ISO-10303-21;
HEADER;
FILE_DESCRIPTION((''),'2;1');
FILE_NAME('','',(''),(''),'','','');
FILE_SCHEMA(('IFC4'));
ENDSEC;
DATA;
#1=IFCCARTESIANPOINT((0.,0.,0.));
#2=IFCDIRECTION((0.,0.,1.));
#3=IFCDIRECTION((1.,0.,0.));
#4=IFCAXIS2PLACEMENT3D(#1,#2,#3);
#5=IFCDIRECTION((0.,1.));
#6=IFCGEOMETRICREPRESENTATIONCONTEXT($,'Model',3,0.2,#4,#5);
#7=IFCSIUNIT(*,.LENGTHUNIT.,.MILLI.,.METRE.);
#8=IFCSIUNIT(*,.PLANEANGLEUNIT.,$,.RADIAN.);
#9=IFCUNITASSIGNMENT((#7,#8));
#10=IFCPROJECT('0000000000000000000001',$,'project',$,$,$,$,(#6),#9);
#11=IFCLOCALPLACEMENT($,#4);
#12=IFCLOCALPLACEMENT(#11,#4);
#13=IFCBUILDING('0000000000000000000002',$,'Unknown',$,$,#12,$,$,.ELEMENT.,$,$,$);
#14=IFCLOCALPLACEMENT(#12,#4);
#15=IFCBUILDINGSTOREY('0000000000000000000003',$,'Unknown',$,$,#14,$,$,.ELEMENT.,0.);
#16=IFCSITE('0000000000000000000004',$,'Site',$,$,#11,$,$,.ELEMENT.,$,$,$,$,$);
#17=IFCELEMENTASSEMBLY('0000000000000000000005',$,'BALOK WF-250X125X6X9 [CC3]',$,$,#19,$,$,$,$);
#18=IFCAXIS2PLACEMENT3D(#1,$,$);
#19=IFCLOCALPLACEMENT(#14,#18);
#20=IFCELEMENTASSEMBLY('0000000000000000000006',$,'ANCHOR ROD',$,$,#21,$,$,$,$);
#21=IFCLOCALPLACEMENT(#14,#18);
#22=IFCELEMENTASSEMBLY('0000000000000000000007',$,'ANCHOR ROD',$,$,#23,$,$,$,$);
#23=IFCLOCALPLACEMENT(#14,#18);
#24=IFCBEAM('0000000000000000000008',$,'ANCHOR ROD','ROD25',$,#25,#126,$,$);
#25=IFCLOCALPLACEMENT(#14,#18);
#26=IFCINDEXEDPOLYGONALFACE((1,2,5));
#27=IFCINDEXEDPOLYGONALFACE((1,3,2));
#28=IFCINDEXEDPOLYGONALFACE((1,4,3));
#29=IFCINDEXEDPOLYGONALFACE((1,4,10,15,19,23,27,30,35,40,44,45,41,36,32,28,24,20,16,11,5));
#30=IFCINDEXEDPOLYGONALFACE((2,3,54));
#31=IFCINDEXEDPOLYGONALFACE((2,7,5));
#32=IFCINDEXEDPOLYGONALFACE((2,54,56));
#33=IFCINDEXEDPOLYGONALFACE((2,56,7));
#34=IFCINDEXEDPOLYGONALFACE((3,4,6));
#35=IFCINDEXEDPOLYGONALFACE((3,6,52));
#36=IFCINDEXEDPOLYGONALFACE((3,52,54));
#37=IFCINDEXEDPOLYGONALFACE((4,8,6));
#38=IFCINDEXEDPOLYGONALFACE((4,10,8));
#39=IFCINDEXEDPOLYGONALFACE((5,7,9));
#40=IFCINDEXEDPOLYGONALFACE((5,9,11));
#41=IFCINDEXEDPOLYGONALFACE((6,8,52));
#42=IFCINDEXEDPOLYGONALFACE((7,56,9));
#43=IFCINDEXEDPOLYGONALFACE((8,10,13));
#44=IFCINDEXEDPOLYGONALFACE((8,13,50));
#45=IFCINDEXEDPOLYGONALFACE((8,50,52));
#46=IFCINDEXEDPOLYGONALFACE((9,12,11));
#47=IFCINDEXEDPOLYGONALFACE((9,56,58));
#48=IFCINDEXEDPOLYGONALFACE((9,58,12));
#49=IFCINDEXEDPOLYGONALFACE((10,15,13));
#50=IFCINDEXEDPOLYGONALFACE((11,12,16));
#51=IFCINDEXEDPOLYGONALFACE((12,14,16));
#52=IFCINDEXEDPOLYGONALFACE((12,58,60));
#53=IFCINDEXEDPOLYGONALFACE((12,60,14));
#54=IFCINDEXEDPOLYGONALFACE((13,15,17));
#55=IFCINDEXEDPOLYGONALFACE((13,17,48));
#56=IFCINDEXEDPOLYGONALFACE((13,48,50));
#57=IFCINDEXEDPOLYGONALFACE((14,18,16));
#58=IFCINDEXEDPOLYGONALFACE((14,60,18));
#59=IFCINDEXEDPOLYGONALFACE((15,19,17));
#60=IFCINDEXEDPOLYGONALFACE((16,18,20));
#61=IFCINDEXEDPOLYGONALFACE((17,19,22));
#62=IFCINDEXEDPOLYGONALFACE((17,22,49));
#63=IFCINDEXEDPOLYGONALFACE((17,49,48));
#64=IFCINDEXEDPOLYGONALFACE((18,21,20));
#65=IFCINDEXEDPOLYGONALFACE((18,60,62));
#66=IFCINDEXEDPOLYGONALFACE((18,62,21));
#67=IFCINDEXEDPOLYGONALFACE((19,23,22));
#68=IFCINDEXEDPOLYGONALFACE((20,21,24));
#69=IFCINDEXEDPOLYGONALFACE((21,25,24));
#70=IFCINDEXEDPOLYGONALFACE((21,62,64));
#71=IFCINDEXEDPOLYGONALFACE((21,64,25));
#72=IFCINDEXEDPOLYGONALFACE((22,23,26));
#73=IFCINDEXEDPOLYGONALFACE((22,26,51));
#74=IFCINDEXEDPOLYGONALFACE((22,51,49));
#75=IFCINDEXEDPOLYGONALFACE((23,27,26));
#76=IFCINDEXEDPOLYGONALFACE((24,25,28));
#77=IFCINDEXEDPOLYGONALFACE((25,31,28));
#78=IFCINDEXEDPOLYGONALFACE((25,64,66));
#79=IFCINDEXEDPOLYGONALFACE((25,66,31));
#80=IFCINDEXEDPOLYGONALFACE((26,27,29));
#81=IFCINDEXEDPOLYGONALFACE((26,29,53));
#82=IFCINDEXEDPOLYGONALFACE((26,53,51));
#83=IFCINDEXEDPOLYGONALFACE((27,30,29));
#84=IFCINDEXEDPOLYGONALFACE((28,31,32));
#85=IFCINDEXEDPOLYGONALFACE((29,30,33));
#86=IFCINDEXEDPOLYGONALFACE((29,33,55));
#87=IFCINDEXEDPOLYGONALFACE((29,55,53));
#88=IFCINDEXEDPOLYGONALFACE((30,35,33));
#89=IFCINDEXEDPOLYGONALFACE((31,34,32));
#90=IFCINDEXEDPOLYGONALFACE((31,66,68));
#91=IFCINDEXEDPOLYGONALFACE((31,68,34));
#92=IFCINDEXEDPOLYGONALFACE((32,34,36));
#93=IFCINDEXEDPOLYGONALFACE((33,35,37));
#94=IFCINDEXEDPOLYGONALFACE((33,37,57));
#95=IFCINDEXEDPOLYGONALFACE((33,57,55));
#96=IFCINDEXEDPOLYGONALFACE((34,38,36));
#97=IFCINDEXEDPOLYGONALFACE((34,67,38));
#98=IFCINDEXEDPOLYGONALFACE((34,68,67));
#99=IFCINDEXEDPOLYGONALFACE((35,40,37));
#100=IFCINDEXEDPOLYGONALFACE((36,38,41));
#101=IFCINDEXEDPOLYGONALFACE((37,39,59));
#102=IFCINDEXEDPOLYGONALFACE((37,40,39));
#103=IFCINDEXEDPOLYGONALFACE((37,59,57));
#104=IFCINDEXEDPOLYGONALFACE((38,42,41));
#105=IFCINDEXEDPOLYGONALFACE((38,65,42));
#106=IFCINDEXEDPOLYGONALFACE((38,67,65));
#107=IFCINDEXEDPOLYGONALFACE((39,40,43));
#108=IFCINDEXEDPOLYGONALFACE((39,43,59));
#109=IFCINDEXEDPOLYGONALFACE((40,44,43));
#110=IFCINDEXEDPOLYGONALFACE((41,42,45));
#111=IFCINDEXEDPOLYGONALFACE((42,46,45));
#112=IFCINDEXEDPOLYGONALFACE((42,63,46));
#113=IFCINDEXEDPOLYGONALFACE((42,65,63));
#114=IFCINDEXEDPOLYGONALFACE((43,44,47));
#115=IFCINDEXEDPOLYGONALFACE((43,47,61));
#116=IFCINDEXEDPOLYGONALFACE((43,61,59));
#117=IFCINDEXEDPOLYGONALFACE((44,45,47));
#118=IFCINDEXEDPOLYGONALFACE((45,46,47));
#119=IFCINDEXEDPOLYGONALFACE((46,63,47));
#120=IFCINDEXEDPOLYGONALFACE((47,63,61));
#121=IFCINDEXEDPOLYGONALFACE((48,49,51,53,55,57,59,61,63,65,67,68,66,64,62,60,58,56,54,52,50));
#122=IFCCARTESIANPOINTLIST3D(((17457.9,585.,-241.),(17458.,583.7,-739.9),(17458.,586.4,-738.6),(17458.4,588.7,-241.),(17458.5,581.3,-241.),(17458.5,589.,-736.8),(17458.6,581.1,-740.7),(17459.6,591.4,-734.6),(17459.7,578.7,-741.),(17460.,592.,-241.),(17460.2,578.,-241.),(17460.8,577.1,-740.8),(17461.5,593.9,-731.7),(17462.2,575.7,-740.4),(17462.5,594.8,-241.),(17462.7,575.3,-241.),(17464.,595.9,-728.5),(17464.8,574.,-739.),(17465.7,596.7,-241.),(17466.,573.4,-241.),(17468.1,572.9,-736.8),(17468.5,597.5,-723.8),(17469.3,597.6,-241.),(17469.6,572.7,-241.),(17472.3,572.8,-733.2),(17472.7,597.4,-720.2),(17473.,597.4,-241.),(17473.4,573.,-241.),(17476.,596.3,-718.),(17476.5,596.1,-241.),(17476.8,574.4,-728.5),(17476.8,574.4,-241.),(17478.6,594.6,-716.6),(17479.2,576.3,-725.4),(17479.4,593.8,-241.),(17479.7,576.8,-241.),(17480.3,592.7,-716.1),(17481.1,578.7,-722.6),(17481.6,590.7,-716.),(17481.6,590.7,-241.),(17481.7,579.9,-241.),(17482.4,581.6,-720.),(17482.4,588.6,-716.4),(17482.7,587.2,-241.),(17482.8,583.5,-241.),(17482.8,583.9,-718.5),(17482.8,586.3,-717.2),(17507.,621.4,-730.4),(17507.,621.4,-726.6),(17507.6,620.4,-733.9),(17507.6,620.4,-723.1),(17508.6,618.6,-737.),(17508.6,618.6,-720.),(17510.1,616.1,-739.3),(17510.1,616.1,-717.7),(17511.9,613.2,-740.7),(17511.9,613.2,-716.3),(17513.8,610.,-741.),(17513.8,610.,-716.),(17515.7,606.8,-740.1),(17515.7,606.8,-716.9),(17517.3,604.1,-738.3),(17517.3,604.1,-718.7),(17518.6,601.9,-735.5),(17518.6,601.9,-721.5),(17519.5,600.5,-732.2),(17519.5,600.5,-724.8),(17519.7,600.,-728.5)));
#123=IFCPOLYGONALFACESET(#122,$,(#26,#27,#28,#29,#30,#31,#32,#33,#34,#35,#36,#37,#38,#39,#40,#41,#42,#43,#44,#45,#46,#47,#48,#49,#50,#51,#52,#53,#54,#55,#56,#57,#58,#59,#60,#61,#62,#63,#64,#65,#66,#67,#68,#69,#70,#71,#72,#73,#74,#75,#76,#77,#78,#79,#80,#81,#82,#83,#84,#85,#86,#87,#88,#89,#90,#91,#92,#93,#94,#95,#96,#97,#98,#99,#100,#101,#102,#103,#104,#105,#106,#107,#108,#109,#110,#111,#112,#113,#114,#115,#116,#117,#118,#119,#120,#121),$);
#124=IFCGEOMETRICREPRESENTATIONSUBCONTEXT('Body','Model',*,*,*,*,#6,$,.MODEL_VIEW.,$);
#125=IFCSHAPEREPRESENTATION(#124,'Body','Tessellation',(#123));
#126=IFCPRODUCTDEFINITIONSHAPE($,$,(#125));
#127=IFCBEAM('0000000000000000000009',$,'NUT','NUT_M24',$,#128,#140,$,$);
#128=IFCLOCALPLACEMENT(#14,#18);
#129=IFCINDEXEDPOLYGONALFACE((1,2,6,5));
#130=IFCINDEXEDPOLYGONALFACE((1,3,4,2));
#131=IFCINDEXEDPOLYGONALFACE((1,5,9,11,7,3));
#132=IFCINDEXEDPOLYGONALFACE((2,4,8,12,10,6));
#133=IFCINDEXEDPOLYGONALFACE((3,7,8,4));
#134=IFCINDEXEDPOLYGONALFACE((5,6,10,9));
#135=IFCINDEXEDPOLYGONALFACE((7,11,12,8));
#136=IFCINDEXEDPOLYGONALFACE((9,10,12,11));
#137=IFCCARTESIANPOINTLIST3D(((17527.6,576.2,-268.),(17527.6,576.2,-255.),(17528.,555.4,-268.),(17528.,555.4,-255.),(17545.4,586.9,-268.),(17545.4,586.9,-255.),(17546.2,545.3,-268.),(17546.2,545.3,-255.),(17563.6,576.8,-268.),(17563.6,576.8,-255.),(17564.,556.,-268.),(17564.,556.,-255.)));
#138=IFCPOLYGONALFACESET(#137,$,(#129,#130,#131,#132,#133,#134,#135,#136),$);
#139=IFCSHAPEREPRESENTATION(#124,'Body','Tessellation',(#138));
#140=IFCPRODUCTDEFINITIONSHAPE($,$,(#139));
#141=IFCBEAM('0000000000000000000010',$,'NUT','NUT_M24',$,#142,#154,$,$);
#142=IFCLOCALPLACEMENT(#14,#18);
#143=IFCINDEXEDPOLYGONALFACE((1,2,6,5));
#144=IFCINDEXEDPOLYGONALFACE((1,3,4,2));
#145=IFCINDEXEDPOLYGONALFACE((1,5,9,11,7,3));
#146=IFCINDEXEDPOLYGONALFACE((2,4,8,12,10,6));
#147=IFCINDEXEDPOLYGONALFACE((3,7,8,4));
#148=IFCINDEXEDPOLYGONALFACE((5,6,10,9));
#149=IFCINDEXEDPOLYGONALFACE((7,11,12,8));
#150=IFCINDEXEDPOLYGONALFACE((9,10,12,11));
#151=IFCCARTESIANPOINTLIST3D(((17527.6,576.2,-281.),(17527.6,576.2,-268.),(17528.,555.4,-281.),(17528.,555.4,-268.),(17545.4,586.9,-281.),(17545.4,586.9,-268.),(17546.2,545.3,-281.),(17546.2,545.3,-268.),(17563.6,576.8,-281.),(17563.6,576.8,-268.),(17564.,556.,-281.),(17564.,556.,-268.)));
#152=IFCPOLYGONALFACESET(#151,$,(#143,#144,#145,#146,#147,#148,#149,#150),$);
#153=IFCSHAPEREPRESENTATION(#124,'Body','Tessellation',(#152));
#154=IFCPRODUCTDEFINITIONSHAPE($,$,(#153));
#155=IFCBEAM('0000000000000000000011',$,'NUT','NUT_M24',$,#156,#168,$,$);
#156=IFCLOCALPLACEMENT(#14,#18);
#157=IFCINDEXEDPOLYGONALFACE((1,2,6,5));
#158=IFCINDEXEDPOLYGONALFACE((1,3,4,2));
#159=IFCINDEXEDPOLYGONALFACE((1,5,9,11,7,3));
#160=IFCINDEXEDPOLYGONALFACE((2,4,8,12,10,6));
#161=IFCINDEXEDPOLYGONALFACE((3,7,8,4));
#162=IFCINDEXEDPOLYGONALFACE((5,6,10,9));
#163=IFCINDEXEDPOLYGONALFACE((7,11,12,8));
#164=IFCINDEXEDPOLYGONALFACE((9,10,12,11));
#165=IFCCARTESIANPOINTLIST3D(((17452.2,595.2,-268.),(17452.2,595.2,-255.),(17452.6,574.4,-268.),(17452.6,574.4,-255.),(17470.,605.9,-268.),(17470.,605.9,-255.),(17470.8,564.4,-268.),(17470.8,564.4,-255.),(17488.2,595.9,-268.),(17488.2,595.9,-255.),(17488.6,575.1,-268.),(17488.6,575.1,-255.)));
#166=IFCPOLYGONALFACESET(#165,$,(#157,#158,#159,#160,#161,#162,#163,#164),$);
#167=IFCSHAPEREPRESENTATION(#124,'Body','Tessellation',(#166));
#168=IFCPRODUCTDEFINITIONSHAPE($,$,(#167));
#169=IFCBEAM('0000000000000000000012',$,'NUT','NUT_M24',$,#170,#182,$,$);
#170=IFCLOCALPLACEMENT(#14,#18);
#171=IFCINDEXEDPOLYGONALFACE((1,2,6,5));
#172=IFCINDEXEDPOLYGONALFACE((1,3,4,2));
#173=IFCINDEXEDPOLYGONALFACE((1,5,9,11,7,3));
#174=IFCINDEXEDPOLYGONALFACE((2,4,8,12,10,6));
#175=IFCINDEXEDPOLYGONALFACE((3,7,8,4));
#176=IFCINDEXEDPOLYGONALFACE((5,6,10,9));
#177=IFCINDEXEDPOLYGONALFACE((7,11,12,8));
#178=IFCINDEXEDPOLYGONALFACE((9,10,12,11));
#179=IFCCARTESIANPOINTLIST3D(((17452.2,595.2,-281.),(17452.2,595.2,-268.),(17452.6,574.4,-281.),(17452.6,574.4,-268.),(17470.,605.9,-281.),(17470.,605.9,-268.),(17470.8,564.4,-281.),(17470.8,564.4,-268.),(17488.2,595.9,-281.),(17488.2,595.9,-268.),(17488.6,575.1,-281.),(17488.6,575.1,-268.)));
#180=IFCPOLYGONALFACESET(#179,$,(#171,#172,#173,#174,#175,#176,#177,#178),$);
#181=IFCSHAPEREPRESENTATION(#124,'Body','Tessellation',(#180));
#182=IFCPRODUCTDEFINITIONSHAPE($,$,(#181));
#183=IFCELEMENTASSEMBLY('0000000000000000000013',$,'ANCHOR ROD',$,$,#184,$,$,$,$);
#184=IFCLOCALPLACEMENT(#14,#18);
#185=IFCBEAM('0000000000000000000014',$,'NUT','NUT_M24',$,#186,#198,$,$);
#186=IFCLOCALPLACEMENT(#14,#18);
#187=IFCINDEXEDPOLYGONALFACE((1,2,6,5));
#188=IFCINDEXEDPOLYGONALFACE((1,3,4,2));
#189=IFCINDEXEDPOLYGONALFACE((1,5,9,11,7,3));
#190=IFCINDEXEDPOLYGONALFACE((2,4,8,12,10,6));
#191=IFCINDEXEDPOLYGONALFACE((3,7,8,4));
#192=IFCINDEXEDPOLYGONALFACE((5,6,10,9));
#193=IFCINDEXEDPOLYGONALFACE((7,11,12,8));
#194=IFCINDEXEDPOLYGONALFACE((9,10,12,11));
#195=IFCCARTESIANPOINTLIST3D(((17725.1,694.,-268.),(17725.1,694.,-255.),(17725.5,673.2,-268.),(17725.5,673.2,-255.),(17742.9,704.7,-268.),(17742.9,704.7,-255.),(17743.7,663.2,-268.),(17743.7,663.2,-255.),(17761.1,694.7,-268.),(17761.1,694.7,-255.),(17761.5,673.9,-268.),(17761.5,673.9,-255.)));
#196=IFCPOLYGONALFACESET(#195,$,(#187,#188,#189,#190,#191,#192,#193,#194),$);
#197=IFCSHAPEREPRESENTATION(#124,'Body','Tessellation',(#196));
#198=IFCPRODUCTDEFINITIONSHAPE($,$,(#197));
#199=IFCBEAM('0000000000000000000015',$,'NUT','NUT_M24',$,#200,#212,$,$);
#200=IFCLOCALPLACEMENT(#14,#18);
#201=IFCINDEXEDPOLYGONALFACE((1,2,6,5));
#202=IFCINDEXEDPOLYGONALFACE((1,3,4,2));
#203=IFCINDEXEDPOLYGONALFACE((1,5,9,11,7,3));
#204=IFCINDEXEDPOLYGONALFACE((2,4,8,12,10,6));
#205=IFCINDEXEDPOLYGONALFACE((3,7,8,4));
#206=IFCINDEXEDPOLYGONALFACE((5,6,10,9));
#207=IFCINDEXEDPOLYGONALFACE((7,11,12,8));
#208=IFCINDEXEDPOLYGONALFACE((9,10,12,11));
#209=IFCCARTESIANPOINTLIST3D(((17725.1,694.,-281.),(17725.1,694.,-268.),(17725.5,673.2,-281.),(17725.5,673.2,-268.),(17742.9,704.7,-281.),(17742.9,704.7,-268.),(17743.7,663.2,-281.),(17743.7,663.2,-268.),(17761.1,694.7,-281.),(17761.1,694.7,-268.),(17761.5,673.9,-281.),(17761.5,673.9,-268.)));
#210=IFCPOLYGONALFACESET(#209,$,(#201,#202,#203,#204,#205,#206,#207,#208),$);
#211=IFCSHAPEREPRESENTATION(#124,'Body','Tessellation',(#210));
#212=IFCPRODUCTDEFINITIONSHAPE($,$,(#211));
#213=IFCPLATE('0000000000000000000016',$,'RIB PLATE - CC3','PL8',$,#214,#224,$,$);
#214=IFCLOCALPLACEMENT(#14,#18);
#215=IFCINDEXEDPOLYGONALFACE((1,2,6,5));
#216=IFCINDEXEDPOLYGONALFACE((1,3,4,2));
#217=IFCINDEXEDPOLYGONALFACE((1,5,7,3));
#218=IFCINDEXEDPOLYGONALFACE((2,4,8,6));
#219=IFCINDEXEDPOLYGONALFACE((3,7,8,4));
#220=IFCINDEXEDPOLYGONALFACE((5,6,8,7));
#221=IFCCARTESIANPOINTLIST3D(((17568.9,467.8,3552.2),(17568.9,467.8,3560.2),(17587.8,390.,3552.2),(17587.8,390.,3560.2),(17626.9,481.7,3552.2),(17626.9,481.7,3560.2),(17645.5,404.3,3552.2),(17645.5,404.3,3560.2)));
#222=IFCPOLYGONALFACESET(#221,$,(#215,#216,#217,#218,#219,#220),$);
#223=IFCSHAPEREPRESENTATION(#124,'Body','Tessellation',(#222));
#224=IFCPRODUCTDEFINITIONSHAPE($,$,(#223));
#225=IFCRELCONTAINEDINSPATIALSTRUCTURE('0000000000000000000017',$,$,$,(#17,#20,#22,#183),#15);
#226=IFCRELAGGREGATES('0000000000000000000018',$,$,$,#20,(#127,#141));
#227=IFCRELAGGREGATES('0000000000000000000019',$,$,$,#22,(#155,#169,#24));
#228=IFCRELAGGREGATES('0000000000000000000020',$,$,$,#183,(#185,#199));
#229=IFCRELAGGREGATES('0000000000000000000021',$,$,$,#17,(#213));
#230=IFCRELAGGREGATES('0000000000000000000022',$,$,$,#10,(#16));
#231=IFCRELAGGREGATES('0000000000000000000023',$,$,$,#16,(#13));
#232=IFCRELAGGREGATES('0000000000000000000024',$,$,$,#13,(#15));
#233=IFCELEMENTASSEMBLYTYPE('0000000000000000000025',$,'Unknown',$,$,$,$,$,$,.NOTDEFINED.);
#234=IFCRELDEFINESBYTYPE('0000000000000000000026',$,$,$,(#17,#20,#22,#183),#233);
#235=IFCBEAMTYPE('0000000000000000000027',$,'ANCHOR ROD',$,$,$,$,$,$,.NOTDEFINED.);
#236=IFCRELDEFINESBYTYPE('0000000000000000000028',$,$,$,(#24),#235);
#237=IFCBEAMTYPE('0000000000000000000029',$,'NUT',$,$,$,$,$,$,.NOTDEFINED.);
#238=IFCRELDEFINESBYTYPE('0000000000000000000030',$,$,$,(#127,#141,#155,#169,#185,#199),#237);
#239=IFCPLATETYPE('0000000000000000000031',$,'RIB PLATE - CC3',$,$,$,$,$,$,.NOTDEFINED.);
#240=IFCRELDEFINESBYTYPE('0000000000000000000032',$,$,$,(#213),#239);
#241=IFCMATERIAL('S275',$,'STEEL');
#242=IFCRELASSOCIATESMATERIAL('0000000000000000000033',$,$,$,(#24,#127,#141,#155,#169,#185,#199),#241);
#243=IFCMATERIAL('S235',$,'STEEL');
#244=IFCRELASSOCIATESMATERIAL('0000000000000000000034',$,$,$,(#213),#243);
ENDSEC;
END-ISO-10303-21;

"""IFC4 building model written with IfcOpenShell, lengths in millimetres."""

from ifc_helpers import new_model, entity, si_unit, direction, frame, origin_with_axes, place, context, subcontext, project, spatial, polyline, line, indexed_curve, outline, extrude, material, material_profile, profile_set, profile_usage, type_object, element, aggregate, save


model = new_model("IFC4")

# Units and contexts
model_context = context("Model", 3, precision=0.2, world=origin_with_axes(), true_north=direction((0.0, 1.0)))
body_context = subcontext(model_context, "Body", "Model", "MODEL_VIEW")
ifc_project = project(units=[si_unit("LENGTHUNIT", "METRE", prefix="MILLI"), si_unit("PLANEANGLEUNIT", "RADIAN")], contexts=[model_context])

# Site, building, storey
site_placement = place(None, origin_with_axes())
site = spatial("IfcSite", under=ifc_project, at=site_placement, Name="Site", CompositionType="ELEMENT")
building_placement = place(site_placement, origin_with_axes())
building = spatial("IfcBuilding", under=site, at=building_placement, Name="Unknown", CompositionType="ELEMENT")
storey_placement = place(building_placement, origin_with_axes())
storey = spatial("IfcBuildingStorey", under=building, at=storey_placement, Name="Unknown", CompositionType="ELEMENT", Elevation=0.0)

# Element assemblies
element_assembly_type = type_object("IfcElementAssemblyType", Name="Unknown", PredefinedType="NOTDEFINED")
assembly_1_placement = place(storey_placement, frame((17628.6, 487.2, 3619.2), z_axis=(-0.972076, -0.234666, 0.0), x_axis=(0.234666, -0.972076, 0.0)))
assembly_1 = element("IfcElementAssembly", 1, at=assembly_1_placement, inside=storey, type_object=element_assembly_type, Name="BALOK WF-250X125X6X9 [CC3]")
assembly_2_placement = place(storey_placement, frame((17545.8, 566.1, -241.0), z_axis=(0.512428, -0.85873, 0.0), x_axis=(0.0, 0.0, -1.0)))
assembly_2 = element("IfcElementAssembly", 2, at=assembly_2_placement, inside=storey, type_object=element_assembly_type, Name="ANCHOR ROD")
ifc_material_1 = material(Name="S275", Category="STEEL")
assembly_3_placement = place(storey_placement, frame((17470.4, 585.1, -241.0), z_axis=(0.512428, -0.85873, 0.0), x_axis=(0.0, 0.0, -1.0)))
assembly_3 = element("IfcElementAssembly", 3, at=assembly_3_placement, inside=storey, type_object=element_assembly_type, Name="ANCHOR ROD")

# Beams
beam_type_1 = type_object("IfcBeamType", Name="ANCHOR ROD", PredefinedType="NOTDEFINED")
beam_1_placement = place(assembly_3_placement, origin_with_axes())
beam_1 = element("IfcBeam", 4, at=beam_1_placement, type_object=beam_type_1, material=ifc_material_1, Name="ANCHOR ROD", Description="ROD25", context=body_context, shape_type="SolidModel", body=[
    entity("IfcSweptDiskSolid", entity("IfcIndexedPolyCurve", entity("IfcCartesianPointList3D", [[0.0, 0.0, 0.0], [487.5, 0.0, 0.0], [487.5, 50.0, 0.0]]), [entity("IfcLineIndex", [1, 2, 3])]), 12.5),
])
ifc_material_profile_1 = material_profile(ifc_material_1, outline(polyline([(18.0, 10.4), (0.0, 20.8), (-18.0, 10.4), (-18.0, -10.4), (0.0, -20.8), (18.0, -10.4), (18.0, 10.4)])), Name="NUT_M24")
ifc_profile_set_1 = profile_set([ifc_material_profile_1])
ifc_profile_usage_1 = profile_usage(ifc_profile_set_1, cardinal=5)
beam_type_2 = type_object("IfcBeamType", Name="NUT", PredefinedType="NOTDEFINED")
beam_2_placement = place(assembly_2_placement, frame((14.0, 0.0, 0.0), z_axis=(0.0, -0.003454, -0.999994), x_axis=(1.0, 0.0, 0.0)))
beam_2 = element("IfcBeam", 5, at=beam_2_placement, type_object=beam_type_2, material=ifc_profile_usage_1, Name="NUT", Description="NUT_M24", context=body_context, shape_type="SolidModel", body=[
    extrude(outline(polyline([(18.0, 10.4), (0.0, 20.8), (-18.0, 10.4), (-18.0, -10.4), (0.0, -20.8), (18.0, -10.4), (18.0, 10.4)])), frame((0.0, 0.0, 0.0), z_axis=(-1.0, 0.0, 0.0), x_axis=(0.0, 0.0, 1.0)), (0.0, 0.0, -1.0), 13.0),
])
beam_3_placement = place(assembly_2_placement, frame((27.0, 0.0, 0.0), z_axis=(0.0, -0.003454, -0.999994), x_axis=(1.0, 0.0, 0.0)))
beam_3 = element("IfcBeam", 6, at=beam_3_placement, type_object=beam_type_2, material=ifc_profile_usage_1, Name="NUT", Description="NUT_M24", context=body_context, shape_type="SolidModel", body=[
    extrude(outline(polyline([(18.0, 10.4), (0.0, 20.8), (-18.0, 10.4), (-18.0, -10.4), (0.0, -20.8), (18.0, -10.4), (18.0, 10.4)])), frame((0.0, 0.0, 0.0), z_axis=(-1.0, 0.0, 0.0), x_axis=(0.0, 0.0, 1.0)), (0.0, 0.0, -1.0), 13.0),
])
aggregate(assembly_2, [beam_2, beam_3])
beam_4_placement = place(assembly_3_placement, frame((14.0, 0.0, 0.0), z_axis=(0.0, -0.003454, -0.999994), x_axis=(1.0, 0.0, 0.0)))
beam_4 = element("IfcBeam", 7, at=beam_4_placement, type_object=beam_type_2, material=ifc_profile_usage_1, Name="NUT", Description="NUT_M24", context=body_context, shape_type="SolidModel", body=[
    extrude(outline(polyline([(18.0, 10.4), (0.0, 20.8), (-18.0, 10.4), (-18.0, -10.4), (0.0, -20.8), (18.0, -10.4), (18.0, 10.4)])), frame((0.0, 0.0, 0.0), z_axis=(-1.0, 0.0, 0.0), x_axis=(0.0, 0.0, 1.0)), (0.0, 0.0, -1.0), 13.0),
])
beam_5_placement = place(assembly_3_placement, frame((27.0, 0.0, 0.0), z_axis=(0.0, -0.003454, -0.999994), x_axis=(1.0, 0.0, 0.0)))
beam_5 = element("IfcBeam", 8, at=beam_5_placement, type_object=beam_type_2, material=ifc_profile_usage_1, Name="NUT", Description="NUT_M24", context=body_context, shape_type="SolidModel", body=[
    extrude(outline(polyline([(18.0, 10.4), (0.0, 20.8), (-18.0, 10.4), (-18.0, -10.4), (0.0, -20.8), (18.0, -10.4), (18.0, 10.4)])), frame((0.0, 0.0, 0.0), z_axis=(-1.0, 0.0, 0.0), x_axis=(0.0, 0.0, 1.0)), (0.0, 0.0, -1.0), 13.0),
])
aggregate(assembly_3, [beam_4, beam_5, beam_1])

# Element assembly, beams
assembly_4_placement = place(storey_placement, frame((17743.3, 684.0, -241.0), z_axis=(-0.512426, 0.858731, 0.0), x_axis=(0.0, 0.0, -1.0)))
assembly_4 = element("IfcElementAssembly", 9, at=assembly_4_placement, inside=storey, type_object=element_assembly_type, Name="ANCHOR ROD")
beam_6_placement = place(assembly_4_placement, frame((14.0, 0.0, 0.0), z_axis=(0.0, 0.003456, 0.999994), x_axis=(1.0, 0.0, 0.0)))
beam_6 = element("IfcBeam", 10, at=beam_6_placement, type_object=beam_type_2, material=ifc_profile_usage_1, Name="NUT", Description="NUT_M24", context=body_context, shape_type="SolidModel", body=[
    extrude(outline(polyline([(18.0, 10.4), (0.0, 20.8), (-18.0, 10.4), (-18.0, -10.4), (0.0, -20.8), (18.0, -10.4), (18.0, 10.4)])), frame((0.0, 0.0, 0.0), z_axis=(-1.0, 0.0, 0.0), x_axis=(0.0, 0.0, 1.0)), (0.0, 0.0, -1.0), 13.0),
])
beam_7_placement = place(assembly_4_placement, frame((27.0, 0.0, 0.0), z_axis=(0.0, 0.003456, 0.999994), x_axis=(1.0, 0.0, 0.0)))
beam_7 = element("IfcBeam", 11, at=beam_7_placement, type_object=beam_type_2, material=ifc_profile_usage_1, Name="NUT", Description="NUT_M24", context=body_context, shape_type="SolidModel", body=[
    extrude(outline(polyline([(18.0, 10.4), (0.0, 20.8), (-18.0, 10.4), (-18.0, -10.4), (0.0, -20.8), (18.0, -10.4), (18.0, 10.4)])), frame((0.0, 0.0, 0.0), z_axis=(-1.0, 0.0, 0.0), x_axis=(0.0, 0.0, 1.0)), (0.0, 0.0, -1.0), 13.0),
])
aggregate(assembly_4, [beam_6, beam_7])

# Plate
ifc_material_2 = material(Name="S235", Category="STEEL")
ifc_material_profile_2 = material_profile(ifc_material_2, outline(indexed_curve([(0.0, 0.0), (80.0, 0.0), (79.8, 59.5), (0.1, 59.6)], segments=[line(1, 2, 3, 4, 1)])), Name="PL8")
ifc_profile_set_2 = profile_set([ifc_material_profile_2])
ifc_profile_usage_2 = profile_usage(ifc_profile_set_2, cardinal=5)
plate_type_1 = type_object("IfcPlateType", Name="RIB PLATE - CC3", PredefinedType="NOTDEFINED")
plate_1_placement = place(assembly_1_placement, frame((4.9, -63.0, 62.6), z_axis=(0.0, 1.0, 0.0), x_axis=(0.999999, 0.0, -0.001595)))
plate_1 = element("IfcPlate", 12, at=plate_1_placement, type_object=plate_type_1, material=ifc_profile_usage_2, Name="RIB PLATE - CC3", Description="PL8", context=body_context, shape_type="SolidModel", body=[
    extrude(outline(indexed_curve([(0.0, 0.0), (80.0, 0.0), (79.8, 59.5), (0.1, 59.6)], segments=[line(1, 2, 3, 4, 1)])), frame((0.0, 0.0, 4.0), z_axis=(0.0, 0.0, 1.0), x_axis=(1.0, 0.0, 0.0)), (0.0, 0.0, -1.0), 8.0),
])
aggregate(assembly_1, [plate_1])

save(model, "model.ifc")
